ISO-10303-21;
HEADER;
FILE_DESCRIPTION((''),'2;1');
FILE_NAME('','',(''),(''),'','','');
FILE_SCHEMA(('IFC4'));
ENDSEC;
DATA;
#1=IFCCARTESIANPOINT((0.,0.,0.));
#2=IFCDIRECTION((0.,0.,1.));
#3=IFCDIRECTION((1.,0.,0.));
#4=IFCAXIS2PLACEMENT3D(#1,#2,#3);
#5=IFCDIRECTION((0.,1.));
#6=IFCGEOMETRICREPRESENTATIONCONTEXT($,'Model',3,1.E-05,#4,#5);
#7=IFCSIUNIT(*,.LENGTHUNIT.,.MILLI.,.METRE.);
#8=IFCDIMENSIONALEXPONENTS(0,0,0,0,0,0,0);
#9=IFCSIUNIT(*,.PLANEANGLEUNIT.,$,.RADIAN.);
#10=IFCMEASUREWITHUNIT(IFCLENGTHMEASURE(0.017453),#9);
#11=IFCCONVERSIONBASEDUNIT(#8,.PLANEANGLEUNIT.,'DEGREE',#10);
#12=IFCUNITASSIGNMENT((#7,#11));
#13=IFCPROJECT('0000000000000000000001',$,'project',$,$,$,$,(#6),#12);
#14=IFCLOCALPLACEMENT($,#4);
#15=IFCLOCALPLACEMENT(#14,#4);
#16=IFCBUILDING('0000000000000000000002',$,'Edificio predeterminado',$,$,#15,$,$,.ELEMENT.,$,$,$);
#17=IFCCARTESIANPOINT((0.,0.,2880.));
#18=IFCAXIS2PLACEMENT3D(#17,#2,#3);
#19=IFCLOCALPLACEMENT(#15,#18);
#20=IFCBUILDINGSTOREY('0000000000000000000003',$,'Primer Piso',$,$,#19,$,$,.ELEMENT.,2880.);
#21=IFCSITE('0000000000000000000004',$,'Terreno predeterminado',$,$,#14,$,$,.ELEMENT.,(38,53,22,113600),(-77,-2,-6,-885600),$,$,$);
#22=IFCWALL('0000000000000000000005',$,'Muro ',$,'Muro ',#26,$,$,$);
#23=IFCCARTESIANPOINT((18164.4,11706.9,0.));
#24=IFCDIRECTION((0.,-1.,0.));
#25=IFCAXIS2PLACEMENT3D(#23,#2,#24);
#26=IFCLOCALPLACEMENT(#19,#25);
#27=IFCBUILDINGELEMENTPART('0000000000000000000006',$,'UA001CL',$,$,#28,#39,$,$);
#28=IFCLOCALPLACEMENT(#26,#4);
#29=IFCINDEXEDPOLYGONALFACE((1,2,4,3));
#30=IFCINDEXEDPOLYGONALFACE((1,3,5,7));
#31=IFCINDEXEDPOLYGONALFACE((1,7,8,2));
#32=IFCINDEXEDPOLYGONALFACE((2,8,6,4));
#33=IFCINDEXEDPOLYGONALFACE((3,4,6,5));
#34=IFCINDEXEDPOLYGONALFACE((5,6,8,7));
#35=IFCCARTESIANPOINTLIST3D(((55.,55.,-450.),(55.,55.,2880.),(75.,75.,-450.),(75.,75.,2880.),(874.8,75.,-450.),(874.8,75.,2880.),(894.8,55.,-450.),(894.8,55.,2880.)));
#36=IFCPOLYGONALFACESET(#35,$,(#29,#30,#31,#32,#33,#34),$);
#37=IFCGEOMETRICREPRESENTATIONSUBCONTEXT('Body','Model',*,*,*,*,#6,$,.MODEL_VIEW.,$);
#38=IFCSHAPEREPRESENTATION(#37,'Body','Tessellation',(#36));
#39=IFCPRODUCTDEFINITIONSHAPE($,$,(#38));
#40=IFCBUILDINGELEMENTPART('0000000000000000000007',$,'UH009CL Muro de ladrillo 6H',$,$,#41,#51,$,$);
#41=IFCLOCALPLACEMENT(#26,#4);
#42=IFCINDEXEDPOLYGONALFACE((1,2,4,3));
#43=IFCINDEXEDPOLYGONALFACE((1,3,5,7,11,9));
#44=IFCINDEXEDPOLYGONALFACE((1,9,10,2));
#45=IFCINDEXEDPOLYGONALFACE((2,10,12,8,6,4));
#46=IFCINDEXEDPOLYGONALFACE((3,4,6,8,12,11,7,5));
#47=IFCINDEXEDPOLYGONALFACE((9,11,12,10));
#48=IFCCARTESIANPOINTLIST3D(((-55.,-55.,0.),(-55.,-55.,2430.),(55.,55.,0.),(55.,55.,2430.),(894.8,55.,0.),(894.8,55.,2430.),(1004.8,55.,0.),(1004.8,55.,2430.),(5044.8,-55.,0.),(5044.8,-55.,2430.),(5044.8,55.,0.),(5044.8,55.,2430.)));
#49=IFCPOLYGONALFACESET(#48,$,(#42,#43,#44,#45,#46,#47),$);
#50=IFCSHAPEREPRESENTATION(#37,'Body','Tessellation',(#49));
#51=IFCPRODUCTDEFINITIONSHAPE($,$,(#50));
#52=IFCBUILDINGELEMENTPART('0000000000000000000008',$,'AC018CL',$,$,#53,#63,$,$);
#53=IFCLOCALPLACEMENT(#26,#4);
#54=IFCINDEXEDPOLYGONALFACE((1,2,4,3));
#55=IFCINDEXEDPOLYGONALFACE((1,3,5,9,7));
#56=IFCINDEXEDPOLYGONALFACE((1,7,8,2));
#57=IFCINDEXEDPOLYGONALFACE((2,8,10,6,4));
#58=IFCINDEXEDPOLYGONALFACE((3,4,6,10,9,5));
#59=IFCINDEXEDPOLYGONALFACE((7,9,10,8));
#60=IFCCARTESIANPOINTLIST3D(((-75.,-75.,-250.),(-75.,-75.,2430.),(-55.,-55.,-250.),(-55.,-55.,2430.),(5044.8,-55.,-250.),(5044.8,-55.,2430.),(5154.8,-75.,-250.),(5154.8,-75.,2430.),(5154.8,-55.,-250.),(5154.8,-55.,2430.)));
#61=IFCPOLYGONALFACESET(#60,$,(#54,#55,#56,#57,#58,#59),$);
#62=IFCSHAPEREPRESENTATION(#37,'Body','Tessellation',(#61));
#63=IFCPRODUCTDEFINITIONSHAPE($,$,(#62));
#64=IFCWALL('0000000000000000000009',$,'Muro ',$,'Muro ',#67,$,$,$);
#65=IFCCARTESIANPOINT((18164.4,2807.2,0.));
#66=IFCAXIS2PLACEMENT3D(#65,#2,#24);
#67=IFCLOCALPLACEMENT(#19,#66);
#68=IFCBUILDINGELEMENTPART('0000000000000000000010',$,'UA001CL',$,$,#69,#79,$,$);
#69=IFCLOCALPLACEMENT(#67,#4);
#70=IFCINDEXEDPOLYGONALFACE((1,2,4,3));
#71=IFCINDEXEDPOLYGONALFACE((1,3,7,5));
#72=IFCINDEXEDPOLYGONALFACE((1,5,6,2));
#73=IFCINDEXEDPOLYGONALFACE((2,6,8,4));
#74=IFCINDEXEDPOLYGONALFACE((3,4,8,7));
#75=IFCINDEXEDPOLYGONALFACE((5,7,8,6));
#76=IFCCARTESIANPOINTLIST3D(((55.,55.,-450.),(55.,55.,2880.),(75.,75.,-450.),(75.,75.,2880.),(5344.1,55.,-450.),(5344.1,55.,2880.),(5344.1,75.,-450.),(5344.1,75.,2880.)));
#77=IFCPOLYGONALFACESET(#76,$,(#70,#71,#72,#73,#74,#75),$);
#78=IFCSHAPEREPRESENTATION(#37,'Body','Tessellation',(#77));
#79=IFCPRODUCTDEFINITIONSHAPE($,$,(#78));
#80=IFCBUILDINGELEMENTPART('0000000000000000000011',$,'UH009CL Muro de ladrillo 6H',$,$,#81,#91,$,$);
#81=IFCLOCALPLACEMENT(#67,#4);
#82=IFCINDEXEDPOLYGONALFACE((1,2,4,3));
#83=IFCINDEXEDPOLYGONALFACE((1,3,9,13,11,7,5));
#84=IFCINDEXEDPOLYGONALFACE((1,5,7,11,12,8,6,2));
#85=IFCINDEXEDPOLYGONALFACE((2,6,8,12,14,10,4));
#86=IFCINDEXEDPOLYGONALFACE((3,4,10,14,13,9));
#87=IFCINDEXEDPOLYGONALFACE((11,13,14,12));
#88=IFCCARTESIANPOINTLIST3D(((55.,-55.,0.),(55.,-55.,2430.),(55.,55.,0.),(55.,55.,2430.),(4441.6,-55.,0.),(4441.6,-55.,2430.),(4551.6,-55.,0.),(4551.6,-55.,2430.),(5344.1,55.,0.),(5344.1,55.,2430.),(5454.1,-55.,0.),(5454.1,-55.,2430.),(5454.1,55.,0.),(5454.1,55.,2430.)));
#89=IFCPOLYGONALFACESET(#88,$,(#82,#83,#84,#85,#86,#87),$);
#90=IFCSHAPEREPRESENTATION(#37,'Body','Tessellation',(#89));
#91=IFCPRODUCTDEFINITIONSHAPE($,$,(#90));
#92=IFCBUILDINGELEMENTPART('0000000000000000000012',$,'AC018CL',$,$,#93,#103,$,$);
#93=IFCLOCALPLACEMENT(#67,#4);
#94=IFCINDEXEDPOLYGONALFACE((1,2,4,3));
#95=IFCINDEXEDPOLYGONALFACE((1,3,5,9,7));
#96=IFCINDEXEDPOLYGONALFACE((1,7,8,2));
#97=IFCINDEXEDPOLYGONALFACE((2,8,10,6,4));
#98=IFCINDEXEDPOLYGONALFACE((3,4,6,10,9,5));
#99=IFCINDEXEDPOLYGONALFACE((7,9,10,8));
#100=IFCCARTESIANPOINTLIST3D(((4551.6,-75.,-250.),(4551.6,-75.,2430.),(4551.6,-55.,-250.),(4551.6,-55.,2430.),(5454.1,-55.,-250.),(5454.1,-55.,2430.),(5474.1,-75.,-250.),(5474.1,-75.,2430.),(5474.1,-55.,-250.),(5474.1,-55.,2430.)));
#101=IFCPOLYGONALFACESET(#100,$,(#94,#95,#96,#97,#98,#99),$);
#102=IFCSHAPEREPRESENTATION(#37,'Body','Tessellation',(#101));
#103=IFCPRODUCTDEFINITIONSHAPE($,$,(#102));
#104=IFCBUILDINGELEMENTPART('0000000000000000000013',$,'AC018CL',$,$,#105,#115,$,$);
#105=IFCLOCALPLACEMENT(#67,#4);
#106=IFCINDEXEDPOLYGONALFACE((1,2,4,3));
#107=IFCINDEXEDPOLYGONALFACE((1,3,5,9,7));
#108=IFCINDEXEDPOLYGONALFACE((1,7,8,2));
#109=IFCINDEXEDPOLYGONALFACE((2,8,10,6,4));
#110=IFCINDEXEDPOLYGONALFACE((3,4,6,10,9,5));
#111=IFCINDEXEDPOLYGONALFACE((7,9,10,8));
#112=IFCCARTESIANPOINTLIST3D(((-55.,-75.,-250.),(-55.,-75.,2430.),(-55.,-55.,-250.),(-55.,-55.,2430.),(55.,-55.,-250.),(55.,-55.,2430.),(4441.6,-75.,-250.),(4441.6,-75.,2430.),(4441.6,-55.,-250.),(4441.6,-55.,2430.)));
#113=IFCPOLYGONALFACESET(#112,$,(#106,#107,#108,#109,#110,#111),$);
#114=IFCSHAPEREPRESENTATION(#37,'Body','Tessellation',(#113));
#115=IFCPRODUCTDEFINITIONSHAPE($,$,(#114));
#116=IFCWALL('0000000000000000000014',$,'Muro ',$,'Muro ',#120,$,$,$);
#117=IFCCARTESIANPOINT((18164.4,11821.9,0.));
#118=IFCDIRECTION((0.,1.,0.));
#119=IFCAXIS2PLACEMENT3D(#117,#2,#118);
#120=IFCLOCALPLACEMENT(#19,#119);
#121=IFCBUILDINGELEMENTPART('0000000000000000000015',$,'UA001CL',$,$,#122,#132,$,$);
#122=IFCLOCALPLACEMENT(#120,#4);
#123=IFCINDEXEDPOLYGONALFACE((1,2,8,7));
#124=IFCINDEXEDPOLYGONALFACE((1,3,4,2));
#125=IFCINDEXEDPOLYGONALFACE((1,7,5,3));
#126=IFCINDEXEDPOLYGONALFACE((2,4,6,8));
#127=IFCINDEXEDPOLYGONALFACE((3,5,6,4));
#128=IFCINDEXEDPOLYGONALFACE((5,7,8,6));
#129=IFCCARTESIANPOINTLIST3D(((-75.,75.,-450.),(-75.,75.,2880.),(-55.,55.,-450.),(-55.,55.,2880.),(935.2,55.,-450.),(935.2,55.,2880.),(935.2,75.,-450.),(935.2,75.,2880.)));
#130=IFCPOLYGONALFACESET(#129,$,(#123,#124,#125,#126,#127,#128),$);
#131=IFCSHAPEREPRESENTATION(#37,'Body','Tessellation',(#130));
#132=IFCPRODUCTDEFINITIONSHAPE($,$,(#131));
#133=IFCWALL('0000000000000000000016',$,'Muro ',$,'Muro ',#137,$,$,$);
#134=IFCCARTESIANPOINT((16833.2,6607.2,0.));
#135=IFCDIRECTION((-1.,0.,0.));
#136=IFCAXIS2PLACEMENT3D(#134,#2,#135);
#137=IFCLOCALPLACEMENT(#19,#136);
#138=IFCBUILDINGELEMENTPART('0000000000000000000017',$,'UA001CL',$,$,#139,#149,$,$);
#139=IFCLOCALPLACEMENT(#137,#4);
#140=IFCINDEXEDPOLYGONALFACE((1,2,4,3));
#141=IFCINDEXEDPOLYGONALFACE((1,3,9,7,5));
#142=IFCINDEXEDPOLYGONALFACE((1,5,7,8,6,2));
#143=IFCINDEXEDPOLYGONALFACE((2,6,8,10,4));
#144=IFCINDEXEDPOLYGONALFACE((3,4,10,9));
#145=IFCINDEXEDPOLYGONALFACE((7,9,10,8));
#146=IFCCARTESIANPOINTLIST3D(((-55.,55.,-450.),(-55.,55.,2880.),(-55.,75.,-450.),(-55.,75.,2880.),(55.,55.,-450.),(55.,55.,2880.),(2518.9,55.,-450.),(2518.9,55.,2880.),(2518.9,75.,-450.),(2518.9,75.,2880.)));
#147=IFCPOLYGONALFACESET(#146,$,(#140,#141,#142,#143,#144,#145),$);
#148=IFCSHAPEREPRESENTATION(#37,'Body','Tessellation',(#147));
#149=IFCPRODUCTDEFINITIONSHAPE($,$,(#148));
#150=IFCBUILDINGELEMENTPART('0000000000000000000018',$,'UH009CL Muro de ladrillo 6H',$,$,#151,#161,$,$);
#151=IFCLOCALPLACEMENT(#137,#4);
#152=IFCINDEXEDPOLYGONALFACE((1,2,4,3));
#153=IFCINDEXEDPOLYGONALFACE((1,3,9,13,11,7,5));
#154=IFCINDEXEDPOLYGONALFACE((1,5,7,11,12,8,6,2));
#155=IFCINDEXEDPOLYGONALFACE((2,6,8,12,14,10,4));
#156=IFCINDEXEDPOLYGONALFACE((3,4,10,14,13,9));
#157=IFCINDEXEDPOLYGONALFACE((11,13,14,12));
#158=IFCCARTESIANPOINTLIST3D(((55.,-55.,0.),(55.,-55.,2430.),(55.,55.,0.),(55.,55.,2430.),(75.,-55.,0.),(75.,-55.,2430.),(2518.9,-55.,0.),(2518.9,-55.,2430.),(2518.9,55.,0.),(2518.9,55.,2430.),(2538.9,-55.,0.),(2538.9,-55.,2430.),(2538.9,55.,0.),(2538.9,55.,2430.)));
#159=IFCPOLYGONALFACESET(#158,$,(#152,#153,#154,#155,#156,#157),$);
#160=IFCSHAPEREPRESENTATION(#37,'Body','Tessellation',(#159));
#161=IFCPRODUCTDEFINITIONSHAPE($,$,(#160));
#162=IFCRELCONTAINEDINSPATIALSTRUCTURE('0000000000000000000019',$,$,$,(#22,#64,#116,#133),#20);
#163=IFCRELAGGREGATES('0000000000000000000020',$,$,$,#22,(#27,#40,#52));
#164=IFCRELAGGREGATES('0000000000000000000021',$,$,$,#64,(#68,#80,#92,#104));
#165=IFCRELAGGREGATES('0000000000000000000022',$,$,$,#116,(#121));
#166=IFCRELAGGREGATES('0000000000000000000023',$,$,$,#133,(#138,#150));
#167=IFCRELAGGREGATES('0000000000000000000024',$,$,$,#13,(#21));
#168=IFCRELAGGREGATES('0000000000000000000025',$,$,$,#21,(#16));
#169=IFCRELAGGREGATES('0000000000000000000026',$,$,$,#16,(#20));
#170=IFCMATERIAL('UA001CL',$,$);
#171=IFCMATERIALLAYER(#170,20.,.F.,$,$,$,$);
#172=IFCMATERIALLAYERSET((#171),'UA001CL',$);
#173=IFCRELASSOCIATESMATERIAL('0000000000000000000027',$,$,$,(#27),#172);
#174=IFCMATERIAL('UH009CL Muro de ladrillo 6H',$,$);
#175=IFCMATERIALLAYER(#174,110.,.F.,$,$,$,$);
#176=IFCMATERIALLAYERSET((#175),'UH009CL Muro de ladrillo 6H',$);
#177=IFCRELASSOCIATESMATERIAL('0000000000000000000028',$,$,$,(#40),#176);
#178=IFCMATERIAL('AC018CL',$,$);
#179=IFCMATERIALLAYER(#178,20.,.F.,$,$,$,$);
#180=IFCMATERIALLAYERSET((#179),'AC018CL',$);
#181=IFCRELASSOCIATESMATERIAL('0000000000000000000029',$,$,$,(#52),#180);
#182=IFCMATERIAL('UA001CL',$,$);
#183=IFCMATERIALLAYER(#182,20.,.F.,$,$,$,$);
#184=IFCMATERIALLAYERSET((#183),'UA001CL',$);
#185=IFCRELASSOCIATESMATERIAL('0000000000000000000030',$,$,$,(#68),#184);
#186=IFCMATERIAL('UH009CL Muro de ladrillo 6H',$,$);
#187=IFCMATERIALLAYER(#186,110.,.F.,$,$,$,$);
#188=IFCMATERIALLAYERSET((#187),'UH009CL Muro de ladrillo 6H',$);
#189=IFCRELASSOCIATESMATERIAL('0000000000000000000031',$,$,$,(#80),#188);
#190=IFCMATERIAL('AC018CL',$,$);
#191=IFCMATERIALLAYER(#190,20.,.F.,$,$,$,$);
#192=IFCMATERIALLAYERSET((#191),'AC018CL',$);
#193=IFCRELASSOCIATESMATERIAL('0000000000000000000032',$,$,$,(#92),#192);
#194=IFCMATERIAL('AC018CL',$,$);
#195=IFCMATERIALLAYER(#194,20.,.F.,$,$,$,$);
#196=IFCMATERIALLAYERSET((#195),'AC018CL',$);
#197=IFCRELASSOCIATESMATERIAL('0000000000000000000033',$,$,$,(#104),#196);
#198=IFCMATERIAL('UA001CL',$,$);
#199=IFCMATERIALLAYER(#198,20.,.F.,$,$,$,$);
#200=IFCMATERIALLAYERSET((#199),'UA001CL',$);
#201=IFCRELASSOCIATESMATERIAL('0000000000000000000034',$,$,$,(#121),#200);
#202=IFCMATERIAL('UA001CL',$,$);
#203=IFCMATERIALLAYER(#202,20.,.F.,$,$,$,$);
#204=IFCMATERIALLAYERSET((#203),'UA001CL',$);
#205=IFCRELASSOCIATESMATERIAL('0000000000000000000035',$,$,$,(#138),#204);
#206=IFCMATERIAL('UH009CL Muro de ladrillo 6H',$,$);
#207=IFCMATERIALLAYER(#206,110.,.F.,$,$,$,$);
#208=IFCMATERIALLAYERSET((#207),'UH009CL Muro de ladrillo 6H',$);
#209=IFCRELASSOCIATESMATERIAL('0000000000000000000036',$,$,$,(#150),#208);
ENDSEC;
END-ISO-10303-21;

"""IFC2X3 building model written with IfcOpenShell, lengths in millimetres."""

from ifc_helpers import new_model, entity, si_unit, converted_unit, direction, frame, origin_with_axes, place, context, subcontext, project, spatial, polyline, outline, extrude, material, layer, layer_set, layer_usage, element, aggregate, save


model = new_model("IFC2X3")

# Units and contexts
model_context = context("Model", 3, precision=1e-05, world=origin_with_axes(), true_north=direction((0.0, 1.0)))
body_context = subcontext(model_context, "Body", "Model", "MODEL_VIEW")
ifc_project = project(units=[si_unit("LENGTHUNIT", "METRE", prefix="MILLI"), converted_unit("PLANEANGLEUNIT", "DEGREE", entity("IfcLengthMeasure", 0.017453), si_unit("PLANEANGLEUNIT", "RADIAN"), dimensions=[0, 0, 0, 0, 0, 0, 0])], contexts=[model_context])

# Site, building, storey
site_placement = place(None, origin_with_axes())
site = spatial("IfcSite", under=ifc_project, at=site_placement, Name="Terreno predeterminado", CompositionType="ELEMENT", RefLatitude=(38, 53, 22, 113600), RefLongitude=(-77, -2, -6, -885600))
building_placement = place(site_placement, origin_with_axes())
building = spatial("IfcBuilding", under=site, at=building_placement, Name="Edificio predeterminado", CompositionType="ELEMENT")
storey_placement = place(building_placement, frame((0.0, 0.0, 2880.0), z_axis=(0.0, 0.0, 1.0), x_axis=(1.0, 0.0, 0.0)))
storey = spatial("IfcBuildingStorey", under=building, at=storey_placement, Name="Primer Piso", CompositionType="ELEMENT", Elevation=2880.0)

# Walls, building element parts
wall_1_placement = place(storey_placement, frame((18164.4, 11706.9, 0.0), z_axis=(0.0, 0.0, 1.0), x_axis=(0.0, -1.0, 0.0)))
wall_1 = element("IfcWall", 1, at=wall_1_placement, inside=storey, Name="Muro ", ObjectType="Muro ")
ifc_material_1 = material(Name="UA001CL")
ifc_layer_1 = layer(ifc_material_1, 20.0, ventilated=False)
ifc_layer_set_1 = layer_set([ifc_layer_1], Name="UA001CL")
ifc_layer_usage_1 = layer_usage(ifc_layer_set_1, "AXIS2", "NEGATIVE", -75.0)
building_element_part_1_placement = place(wall_1_placement, origin_with_axes())
building_element_part_1 = element("IfcBuildingElementPart", 2, at=building_element_part_1_placement, material=ifc_layer_usage_1, Name="UA001CL", context=body_context, shape_type="SweptSolid", body=[
    extrude(outline(polyline([(874.8, 75.0), (894.8, 55.0), (55.0, 55.0), (75.0, 75.0), (874.8, 75.0)])), frame((0.0, 0.0, -450.0), z_axis=(0.0, 0.0, 1.0), x_axis=(1.0, 0.0, 0.0)), (0.0, 0.0, 1.0), 3330.0),
])
ifc_material_2 = material(Name="UH009CL Muro de ladrillo 6H")
ifc_layer_2 = layer(ifc_material_2, 110.0, ventilated=False)
ifc_layer_set_2 = layer_set([ifc_layer_2], Name="UH009CL Muro de ladrillo 6H")
ifc_layer_usage_2 = layer_usage(ifc_layer_set_2, "AXIS2", "NEGATIVE", -55.0)
building_element_part_2_placement = place(wall_1_placement, origin_with_axes())
building_element_part_2 = element("IfcBuildingElementPart", 3, at=building_element_part_2_placement, material=ifc_layer_usage_2, Name="UH009CL Muro de ladrillo 6H", context=body_context, shape_type="SweptSolid", body=[
    extrude(outline(polyline([(5044.8, 55.0), (5044.8, -55.0), (-55.0, -55.0), (55.0, 55.0), (894.8, 55.0), (1004.8, 55.0), (5044.8, 55.0)])), origin_with_axes(), (0.0, 0.0, 1.0), 2430.0),
])
ifc_material_3 = material(Name="AC018CL")
ifc_layer_3 = layer(ifc_material_3, 20.0, ventilated=False)
ifc_layer_set_3 = layer_set([ifc_layer_3], Name="AC018CL")
ifc_layer_usage_3 = layer_usage(ifc_layer_set_3, "AXIS2", "NEGATIVE", 55.0)
building_element_part_3_placement = place(wall_1_placement, origin_with_axes())
building_element_part_3 = element("IfcBuildingElementPart", 4, at=building_element_part_3_placement, material=ifc_layer_usage_3, Name="AC018CL", context=body_context, shape_type="SweptSolid", body=[
    extrude(outline(polyline([(5154.8, -55.0), (5154.8, -75.0), (-75.0, -75.0), (-55.0, -55.0), (5044.8, -55.0), (5154.8, -55.0)])), frame((0.0, 0.0, -250.0), z_axis=(0.0, 0.0, 1.0), x_axis=(1.0, 0.0, 0.0)), (0.0, 0.0, 1.0), 2680.0),
])
aggregate(wall_1, [building_element_part_1, building_element_part_2, building_element_part_3])
wall_2_placement = place(storey_placement, frame((18164.4, 2807.2, 0.0), z_axis=(0.0, 0.0, 1.0), x_axis=(0.0, -1.0, 0.0)))
wall_2 = element("IfcWall", 5, at=wall_2_placement, inside=storey, Name="Muro ", ObjectType="Muro ")
ifc_material_4 = material(Name="UA001CL")
ifc_layer_4 = layer(ifc_material_4, 20.0, ventilated=False)
ifc_layer_set_4 = layer_set([ifc_layer_4], Name="UA001CL")
ifc_layer_usage_4 = layer_usage(ifc_layer_set_4, "AXIS2", "NEGATIVE", -75.0)
building_element_part_4_placement = place(wall_2_placement, origin_with_axes())
building_element_part_4 = element("IfcBuildingElementPart", 6, at=building_element_part_4_placement, material=ifc_layer_usage_4, Name="UA001CL", context=body_context, shape_type="SweptSolid", body=[
    extrude(outline(polyline([(5344.1, 75.0), (5344.1, 55.0), (55.0, 55.0), (75.0, 75.0), (5344.1, 75.0)])), frame((0.0, 0.0, -450.0), z_axis=(0.0, 0.0, 1.0), x_axis=(1.0, 0.0, 0.0)), (0.0, 0.0, 1.0), 3330.0),
])
ifc_material_5 = material(Name="UH009CL Muro de ladrillo 6H")
ifc_layer_5 = layer(ifc_material_5, 110.0, ventilated=False)
ifc_layer_set_5 = layer_set([ifc_layer_5], Name="UH009CL Muro de ladrillo 6H")
ifc_layer_usage_5 = layer_usage(ifc_layer_set_5, "AXIS2", "NEGATIVE", -55.0)
building_element_part_5_placement = place(wall_2_placement, origin_with_axes())
building_element_part_5 = element("IfcBuildingElementPart", 7, at=building_element_part_5_placement, material=ifc_layer_usage_5, Name="UH009CL Muro de ladrillo 6H", context=body_context, shape_type="SweptSolid", body=[
    extrude(outline(polyline([(5454.1, 55.0), (5454.1, -55.0), (4551.6, -55.0), (4441.6, -55.0), (55.0, -55.0), (55.0, 55.0), (5344.1, 55.0), (5454.1, 55.0)])), origin_with_axes(), (0.0, 0.0, 1.0), 2430.0),
])
ifc_material_6 = material(Name="AC018CL")
ifc_layer_6 = layer(ifc_material_6, 20.0, ventilated=False)
ifc_layer_set_6 = layer_set([ifc_layer_6], Name="AC018CL")
ifc_layer_usage_6 = layer_usage(ifc_layer_set_6, "AXIS2", "NEGATIVE", 55.0)
building_element_part_6_placement = place(wall_2_placement, origin_with_axes())
building_element_part_6 = element("IfcBuildingElementPart", 8, at=building_element_part_6_placement, material=ifc_layer_usage_6, Name="AC018CL", context=body_context, shape_type="SweptSolid", body=[
    extrude(outline(polyline([(5474.1, -55.0), (5474.1, -75.0), (4551.6, -75.0), (4551.6, -55.0), (5454.1, -55.0), (5474.1, -55.0)])), frame((0.0, 0.0, -250.0), z_axis=(0.0, 0.0, 1.0), x_axis=(1.0, 0.0, 0.0)), (0.0, 0.0, 1.0), 2680.0),
])
ifc_material_7 = material(Name="AC018CL")
ifc_layer_7 = layer(ifc_material_7, 20.0, ventilated=False)
ifc_layer_set_7 = layer_set([ifc_layer_7], Name="AC018CL")
ifc_layer_usage_7 = layer_usage(ifc_layer_set_7, "AXIS2", "NEGATIVE", 55.0)
building_element_part_7_placement = place(wall_2_placement, origin_with_axes())
building_element_part_7 = element("IfcBuildingElementPart", 9, at=building_element_part_7_placement, material=ifc_layer_usage_7, Name="AC018CL", context=body_context, shape_type="SweptSolid", body=[
    extrude(outline(polyline([(4441.6, -55.0), (4441.6, -75.0), (-55.0, -75.0), (-55.0, -55.0), (55.0, -55.0), (4441.6, -55.0)])), frame((0.0, 0.0, -250.0), z_axis=(0.0, 0.0, 1.0), x_axis=(1.0, 0.0, 0.0)), (0.0, 0.0, 1.0), 2680.0),
])
aggregate(wall_2, [building_element_part_4, building_element_part_5, building_element_part_6, building_element_part_7])

# Wall, building element part
wall_3_placement = place(storey_placement, frame((18164.4, 11821.9, 0.0), z_axis=(0.0, 0.0, 1.0), x_axis=(0.0, 1.0, 0.0)))
wall_3 = element("IfcWall", 10, at=wall_3_placement, inside=storey, Name="Muro ", ObjectType="Muro ")
ifc_material_8 = material(Name="UA001CL")
ifc_layer_8 = layer(ifc_material_8, 20.0, ventilated=False)
ifc_layer_set_8 = layer_set([ifc_layer_8], Name="UA001CL")
ifc_layer_usage_8 = layer_usage(ifc_layer_set_8, "AXIS2", "NEGATIVE", -75.0)
building_element_part_8_placement = place(wall_3_placement, origin_with_axes())
building_element_part_8 = element("IfcBuildingElementPart", 11, at=building_element_part_8_placement, material=ifc_layer_usage_8, Name="UA001CL", context=body_context, shape_type="SweptSolid", body=[
    extrude(outline(polyline([(935.2, 75.0), (935.2, 55.0), (-55.0, 55.0), (-75.0, 75.0), (935.2, 75.0)])), frame((0.0, 0.0, -450.0), z_axis=(0.0, 0.0, 1.0), x_axis=(1.0, 0.0, 0.0)), (0.0, 0.0, 1.0), 3330.0),
])
aggregate(wall_3, [building_element_part_8])

# Wall, building element parts
wall_4_placement = place(storey_placement, frame((16833.2, 6607.2, 0.0), z_axis=(0.0, 0.0, 1.0), x_axis=(-1.0, 0.0, 0.0)))
wall_4 = element("IfcWall", 12, at=wall_4_placement, inside=storey, Name="Muro ", ObjectType="Muro ")
ifc_material_9 = material(Name="UA001CL")
ifc_layer_9 = layer(ifc_material_9, 20.0, ventilated=False)
ifc_layer_set_9 = layer_set([ifc_layer_9], Name="UA001CL")
ifc_layer_usage_9 = layer_usage(ifc_layer_set_9, "AXIS2", "NEGATIVE", -75.0)
building_element_part_9_placement = place(wall_4_placement, origin_with_axes())
building_element_part_9 = element("IfcBuildingElementPart", 13, at=building_element_part_9_placement, material=ifc_layer_usage_9, Name="UA001CL", context=body_context, shape_type="SweptSolid", body=[
    extrude(outline(polyline([(2518.9, 75.0), (2518.9, 55.0), (55.0, 55.0), (-55.0, 55.0), (-55.0, 75.0), (2518.9, 75.0)])), frame((0.0, 0.0, -450.0), z_axis=(0.0, 0.0, 1.0), x_axis=(1.0, 0.0, 0.0)), (0.0, 0.0, 1.0), 3330.0),
])
ifc_material_10 = material(Name="UH009CL Muro de ladrillo 6H")
ifc_layer_10 = layer(ifc_material_10, 110.0, ventilated=False)
ifc_layer_set_10 = layer_set([ifc_layer_10], Name="UH009CL Muro de ladrillo 6H")
ifc_layer_usage_10 = layer_usage(ifc_layer_set_10, "AXIS2", "NEGATIVE", -55.0)
building_element_part_10_placement = place(wall_4_placement, origin_with_axes())
building_element_part_10 = element("IfcBuildingElementPart", 14, at=building_element_part_10_placement, material=ifc_layer_usage_10, Name="UH009CL Muro de ladrillo 6H", context=body_context, shape_type="SweptSolid", body=[
    extrude(outline(polyline([(2538.9, 55.0), (2538.9, -55.0), (2518.9, -55.0), (75.0, -55.0), (55.0, -55.0), (55.0, 55.0), (2518.9, 55.0), (2538.9, 55.0)])), origin_with_axes(), (0.0, 0.0, 1.0), 2430.0),
])
aggregate(wall_4, [building_element_part_9, building_element_part_10])

save(model, "model.ifc")
